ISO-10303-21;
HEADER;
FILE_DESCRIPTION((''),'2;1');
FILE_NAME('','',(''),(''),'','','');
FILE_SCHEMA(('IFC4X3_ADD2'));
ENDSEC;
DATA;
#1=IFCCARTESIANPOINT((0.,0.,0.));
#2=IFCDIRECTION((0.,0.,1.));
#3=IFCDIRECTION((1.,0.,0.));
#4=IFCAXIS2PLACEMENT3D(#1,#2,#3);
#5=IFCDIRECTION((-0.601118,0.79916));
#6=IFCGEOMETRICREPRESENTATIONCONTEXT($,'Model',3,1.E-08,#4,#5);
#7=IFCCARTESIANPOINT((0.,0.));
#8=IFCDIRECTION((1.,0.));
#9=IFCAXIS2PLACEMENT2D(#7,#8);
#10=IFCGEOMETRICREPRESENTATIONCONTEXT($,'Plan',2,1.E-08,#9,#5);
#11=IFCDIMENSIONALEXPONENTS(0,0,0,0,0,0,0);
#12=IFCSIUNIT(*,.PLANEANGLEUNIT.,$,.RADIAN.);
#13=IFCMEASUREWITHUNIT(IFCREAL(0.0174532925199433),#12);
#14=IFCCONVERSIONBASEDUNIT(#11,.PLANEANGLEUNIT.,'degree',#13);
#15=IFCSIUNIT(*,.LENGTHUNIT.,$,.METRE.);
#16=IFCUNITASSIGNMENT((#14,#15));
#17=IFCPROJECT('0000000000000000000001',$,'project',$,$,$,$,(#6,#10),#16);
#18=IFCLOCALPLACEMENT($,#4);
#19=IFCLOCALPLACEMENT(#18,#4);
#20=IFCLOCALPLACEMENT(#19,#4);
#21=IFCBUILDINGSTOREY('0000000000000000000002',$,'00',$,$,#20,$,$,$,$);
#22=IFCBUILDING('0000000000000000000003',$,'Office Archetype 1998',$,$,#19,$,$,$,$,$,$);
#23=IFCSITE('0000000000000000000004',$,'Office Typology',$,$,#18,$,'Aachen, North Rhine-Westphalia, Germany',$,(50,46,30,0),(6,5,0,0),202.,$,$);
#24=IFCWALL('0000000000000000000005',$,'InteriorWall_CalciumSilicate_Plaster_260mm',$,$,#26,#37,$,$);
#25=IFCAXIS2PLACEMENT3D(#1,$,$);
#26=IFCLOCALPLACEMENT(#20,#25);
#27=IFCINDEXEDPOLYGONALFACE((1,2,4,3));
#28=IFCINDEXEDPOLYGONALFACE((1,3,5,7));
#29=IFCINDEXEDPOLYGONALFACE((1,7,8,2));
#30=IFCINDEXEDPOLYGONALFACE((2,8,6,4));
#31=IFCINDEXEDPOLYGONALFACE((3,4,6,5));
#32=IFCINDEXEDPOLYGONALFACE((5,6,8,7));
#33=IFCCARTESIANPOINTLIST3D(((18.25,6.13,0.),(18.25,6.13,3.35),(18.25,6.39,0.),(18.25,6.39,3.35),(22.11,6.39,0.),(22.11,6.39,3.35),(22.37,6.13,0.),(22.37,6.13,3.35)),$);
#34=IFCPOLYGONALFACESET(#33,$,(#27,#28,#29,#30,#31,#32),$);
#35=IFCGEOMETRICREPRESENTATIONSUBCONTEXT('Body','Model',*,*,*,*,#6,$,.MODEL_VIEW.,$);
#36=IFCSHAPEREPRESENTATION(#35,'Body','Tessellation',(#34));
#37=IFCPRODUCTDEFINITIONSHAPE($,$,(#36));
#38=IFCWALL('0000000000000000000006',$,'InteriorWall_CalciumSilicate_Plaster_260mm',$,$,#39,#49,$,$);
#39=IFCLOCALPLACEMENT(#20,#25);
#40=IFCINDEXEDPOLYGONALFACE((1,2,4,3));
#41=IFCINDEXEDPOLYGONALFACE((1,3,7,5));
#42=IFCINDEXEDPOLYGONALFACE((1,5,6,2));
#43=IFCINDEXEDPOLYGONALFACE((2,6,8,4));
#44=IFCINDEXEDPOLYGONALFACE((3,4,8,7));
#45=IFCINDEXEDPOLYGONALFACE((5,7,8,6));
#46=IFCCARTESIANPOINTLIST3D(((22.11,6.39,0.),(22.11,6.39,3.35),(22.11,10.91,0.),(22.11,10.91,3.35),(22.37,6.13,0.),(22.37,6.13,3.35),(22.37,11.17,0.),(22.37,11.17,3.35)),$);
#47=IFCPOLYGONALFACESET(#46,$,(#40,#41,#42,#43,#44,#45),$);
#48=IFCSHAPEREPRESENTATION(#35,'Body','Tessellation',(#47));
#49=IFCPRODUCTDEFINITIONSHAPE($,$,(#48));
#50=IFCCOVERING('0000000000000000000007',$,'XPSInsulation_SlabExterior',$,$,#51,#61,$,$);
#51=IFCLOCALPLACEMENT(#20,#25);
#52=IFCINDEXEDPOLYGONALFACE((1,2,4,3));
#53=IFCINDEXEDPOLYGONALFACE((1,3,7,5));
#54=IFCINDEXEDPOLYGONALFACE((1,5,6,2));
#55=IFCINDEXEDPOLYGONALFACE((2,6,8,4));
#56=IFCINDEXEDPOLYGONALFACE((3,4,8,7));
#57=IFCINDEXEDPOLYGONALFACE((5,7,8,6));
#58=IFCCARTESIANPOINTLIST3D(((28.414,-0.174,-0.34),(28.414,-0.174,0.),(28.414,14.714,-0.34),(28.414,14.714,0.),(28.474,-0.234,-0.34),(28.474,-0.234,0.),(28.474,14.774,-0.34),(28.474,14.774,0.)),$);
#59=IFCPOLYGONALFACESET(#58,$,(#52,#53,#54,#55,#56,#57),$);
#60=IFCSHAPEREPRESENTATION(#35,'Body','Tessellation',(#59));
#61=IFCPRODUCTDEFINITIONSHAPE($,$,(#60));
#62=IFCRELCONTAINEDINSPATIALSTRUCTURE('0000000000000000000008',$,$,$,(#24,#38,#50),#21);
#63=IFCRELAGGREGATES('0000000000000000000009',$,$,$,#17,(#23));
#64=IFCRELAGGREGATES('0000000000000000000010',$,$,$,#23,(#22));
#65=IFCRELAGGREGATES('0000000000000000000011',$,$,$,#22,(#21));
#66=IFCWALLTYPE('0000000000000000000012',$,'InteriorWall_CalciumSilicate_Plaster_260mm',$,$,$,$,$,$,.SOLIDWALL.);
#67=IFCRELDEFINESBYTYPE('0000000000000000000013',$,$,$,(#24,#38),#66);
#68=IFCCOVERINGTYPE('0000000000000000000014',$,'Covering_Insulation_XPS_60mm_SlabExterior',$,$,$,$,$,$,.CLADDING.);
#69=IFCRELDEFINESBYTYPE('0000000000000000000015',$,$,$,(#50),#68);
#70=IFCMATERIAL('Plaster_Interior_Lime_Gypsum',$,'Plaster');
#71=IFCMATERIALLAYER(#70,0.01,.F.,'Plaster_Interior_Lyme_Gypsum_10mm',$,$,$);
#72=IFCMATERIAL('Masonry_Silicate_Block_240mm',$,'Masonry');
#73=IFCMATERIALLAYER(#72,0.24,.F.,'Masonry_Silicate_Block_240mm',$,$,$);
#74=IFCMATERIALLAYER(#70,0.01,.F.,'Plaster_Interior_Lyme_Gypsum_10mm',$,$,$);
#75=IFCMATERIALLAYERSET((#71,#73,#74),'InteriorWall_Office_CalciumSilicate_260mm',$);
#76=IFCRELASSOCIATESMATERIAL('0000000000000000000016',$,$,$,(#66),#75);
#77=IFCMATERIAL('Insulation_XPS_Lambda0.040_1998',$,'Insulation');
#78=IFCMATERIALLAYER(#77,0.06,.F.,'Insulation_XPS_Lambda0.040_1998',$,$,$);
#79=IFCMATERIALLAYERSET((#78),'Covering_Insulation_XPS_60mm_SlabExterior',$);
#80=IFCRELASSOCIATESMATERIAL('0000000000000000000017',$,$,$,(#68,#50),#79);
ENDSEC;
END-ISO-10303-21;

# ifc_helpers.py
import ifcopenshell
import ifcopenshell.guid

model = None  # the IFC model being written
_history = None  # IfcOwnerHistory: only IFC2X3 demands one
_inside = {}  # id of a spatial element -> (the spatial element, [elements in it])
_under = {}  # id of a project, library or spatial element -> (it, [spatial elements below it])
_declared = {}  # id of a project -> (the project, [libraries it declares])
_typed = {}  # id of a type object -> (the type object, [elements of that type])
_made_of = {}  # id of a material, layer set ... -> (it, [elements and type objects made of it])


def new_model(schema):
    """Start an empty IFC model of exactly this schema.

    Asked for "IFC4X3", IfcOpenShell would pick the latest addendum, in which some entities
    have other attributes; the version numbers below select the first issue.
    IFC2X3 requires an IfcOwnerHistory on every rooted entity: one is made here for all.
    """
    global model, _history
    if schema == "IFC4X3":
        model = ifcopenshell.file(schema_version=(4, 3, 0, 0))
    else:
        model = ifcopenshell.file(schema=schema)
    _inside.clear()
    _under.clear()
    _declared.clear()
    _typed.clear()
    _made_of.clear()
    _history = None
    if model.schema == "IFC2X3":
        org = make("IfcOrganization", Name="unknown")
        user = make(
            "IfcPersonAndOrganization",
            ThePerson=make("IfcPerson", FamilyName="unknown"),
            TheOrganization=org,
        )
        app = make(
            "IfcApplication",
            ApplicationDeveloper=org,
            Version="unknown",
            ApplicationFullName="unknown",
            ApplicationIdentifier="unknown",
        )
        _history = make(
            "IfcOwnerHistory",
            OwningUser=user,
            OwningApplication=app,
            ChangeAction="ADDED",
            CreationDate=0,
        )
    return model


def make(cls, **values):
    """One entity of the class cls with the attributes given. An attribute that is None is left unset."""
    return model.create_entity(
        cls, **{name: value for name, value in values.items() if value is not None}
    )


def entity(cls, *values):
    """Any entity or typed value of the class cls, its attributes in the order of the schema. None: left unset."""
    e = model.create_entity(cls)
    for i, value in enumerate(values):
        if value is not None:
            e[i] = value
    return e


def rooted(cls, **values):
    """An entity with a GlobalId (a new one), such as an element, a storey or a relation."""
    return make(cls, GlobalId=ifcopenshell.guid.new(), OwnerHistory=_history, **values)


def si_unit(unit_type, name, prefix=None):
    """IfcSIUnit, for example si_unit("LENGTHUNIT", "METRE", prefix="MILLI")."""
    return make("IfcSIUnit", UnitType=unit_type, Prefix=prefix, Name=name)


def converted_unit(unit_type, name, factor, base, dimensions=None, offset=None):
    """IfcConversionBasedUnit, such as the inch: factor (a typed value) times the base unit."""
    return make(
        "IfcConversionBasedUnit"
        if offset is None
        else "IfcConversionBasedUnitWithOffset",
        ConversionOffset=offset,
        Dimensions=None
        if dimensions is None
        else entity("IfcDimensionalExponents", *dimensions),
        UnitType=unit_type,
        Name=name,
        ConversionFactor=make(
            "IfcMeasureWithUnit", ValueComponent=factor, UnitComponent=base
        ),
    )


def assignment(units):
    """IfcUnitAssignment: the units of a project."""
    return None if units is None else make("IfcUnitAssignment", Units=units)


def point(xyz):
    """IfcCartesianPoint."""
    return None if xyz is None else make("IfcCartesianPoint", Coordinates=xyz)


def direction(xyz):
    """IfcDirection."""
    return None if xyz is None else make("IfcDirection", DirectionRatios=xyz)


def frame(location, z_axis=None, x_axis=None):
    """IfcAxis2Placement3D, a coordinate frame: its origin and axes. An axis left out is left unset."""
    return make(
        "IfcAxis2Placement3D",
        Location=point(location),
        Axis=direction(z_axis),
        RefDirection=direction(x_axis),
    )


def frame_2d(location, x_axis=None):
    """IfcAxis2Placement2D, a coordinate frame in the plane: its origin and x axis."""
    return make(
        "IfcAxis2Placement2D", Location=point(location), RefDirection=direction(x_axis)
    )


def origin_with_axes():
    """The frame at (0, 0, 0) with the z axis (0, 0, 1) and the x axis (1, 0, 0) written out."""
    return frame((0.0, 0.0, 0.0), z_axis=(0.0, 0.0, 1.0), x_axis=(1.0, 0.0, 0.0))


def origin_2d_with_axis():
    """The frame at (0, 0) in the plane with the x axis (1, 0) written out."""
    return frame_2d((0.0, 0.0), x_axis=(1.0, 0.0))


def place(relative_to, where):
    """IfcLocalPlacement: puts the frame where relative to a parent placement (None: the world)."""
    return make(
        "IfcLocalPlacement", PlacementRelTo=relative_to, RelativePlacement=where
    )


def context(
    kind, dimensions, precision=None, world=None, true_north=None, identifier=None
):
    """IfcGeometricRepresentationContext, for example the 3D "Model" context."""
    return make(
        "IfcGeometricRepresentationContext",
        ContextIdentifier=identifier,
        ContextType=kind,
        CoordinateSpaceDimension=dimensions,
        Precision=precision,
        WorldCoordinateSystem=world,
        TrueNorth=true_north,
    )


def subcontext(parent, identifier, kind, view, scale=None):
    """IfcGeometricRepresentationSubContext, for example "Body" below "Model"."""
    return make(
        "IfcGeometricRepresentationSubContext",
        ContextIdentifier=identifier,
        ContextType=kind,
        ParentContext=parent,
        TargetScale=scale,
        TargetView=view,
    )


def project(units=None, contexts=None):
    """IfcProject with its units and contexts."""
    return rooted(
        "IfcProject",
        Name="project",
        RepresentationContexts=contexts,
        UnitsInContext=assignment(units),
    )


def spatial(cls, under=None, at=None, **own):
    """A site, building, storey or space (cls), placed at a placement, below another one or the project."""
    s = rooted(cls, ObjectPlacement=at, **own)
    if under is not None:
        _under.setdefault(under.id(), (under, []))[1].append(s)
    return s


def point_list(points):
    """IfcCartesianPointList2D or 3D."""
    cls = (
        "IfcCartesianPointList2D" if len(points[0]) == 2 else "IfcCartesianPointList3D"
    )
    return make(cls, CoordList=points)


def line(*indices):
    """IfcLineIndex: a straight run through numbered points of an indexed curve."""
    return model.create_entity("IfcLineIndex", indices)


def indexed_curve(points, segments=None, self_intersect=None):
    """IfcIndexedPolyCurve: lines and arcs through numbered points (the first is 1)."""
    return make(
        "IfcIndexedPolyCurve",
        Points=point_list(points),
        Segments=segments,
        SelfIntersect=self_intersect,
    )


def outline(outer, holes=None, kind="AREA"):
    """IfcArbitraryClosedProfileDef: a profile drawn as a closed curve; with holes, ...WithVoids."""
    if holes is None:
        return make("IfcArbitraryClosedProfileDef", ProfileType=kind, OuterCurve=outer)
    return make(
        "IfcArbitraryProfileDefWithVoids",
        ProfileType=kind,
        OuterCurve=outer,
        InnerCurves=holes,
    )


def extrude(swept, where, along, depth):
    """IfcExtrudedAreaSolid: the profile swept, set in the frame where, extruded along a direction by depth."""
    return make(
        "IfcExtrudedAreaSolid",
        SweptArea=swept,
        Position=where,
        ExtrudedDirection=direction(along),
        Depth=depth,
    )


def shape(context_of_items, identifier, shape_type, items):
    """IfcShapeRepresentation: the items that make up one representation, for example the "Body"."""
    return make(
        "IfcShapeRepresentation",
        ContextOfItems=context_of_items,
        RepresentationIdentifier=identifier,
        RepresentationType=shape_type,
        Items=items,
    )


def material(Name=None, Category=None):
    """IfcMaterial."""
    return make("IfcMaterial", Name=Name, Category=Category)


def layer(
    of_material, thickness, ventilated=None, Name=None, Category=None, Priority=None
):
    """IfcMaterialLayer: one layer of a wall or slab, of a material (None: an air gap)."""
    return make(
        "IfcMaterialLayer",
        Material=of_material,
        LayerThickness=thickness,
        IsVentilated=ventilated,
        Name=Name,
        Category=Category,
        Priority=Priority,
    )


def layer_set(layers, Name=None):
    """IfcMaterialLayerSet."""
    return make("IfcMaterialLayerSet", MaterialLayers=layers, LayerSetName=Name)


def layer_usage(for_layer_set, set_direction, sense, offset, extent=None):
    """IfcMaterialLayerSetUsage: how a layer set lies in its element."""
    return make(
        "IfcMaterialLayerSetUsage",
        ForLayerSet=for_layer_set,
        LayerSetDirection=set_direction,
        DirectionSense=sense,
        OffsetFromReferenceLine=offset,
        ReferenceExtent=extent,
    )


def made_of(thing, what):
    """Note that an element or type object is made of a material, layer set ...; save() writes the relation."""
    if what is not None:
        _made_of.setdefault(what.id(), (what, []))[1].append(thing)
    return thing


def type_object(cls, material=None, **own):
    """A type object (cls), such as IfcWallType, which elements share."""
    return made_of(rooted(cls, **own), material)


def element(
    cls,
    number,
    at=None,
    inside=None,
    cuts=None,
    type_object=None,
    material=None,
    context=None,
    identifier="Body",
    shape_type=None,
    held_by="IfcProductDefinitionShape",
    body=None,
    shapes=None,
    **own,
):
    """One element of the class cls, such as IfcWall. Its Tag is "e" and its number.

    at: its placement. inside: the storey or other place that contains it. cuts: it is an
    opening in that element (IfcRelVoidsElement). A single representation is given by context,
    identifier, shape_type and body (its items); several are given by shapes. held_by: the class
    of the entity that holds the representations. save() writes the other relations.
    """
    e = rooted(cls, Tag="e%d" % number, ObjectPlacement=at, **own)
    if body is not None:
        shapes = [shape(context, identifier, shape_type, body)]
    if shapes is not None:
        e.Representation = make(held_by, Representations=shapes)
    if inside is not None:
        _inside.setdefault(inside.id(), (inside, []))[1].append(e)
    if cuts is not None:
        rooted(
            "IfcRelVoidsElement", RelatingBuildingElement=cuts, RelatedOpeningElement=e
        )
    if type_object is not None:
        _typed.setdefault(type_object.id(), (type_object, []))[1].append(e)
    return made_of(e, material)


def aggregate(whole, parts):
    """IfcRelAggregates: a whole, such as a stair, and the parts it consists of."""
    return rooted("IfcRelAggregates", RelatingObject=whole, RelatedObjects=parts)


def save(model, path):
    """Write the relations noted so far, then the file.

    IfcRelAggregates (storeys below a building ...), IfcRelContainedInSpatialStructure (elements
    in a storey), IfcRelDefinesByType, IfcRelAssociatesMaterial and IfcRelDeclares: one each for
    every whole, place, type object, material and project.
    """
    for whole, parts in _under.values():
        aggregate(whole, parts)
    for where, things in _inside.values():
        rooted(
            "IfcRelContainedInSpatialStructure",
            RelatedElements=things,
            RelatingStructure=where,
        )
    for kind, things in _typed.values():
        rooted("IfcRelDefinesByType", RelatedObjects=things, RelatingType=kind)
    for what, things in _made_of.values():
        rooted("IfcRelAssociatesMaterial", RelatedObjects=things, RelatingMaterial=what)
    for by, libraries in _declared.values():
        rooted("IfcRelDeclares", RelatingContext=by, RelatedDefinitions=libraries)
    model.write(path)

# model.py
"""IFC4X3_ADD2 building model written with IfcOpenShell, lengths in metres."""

from ifc_helpers import new_model, entity, si_unit, converted_unit, direction, frame, origin_with_axes, origin_2d_with_axis, place, context, subcontext, project, spatial, line, indexed_curve, outline, extrude, material, layer, layer_set, layer_usage, type_object, element, save


model = new_model("IFC4X3_ADD2")

# Units and contexts
model_context = context("Model", 3, precision=1e-08, world=origin_with_axes(), true_north=direction((-0.601118, 0.79916)))
plan_context = context("Plan", 2, precision=1e-08, world=origin_2d_with_axis(), true_north=direction((-0.601118, 0.79916)))
body_context = subcontext(model_context, "Body", "Model", "MODEL_VIEW")
ifc_project = project(units=[converted_unit("PLANEANGLEUNIT", "degree", entity("IfcReal", 0.0174532925199433), si_unit("PLANEANGLEUNIT", "RADIAN"), dimensions=[0, 0, 0, 0, 0, 0, 0]), si_unit("LENGTHUNIT", "METRE")], contexts=[model_context, plan_context])

# Site, building, storey
site_placement = place(None, origin_with_axes())
site = spatial("IfcSite", under=ifc_project, at=site_placement, Name="Office Typology", LongName="Aachen, North Rhine-Westphalia, Germany", RefLatitude=(50, 46, 30, 0), RefLongitude=(6, 5, 0, 0), RefElevation=202.0)
building_placement = place(site_placement, origin_with_axes())
building = spatial("IfcBuilding", under=site, at=building_placement, Name="Office Archetype 1998")
storey_placement = place(building_placement, origin_with_axes())
storey = spatial("IfcBuildingStorey", under=building, at=storey_placement, Name="00")

# Walls
ifc_material_1 = material(Name="Plaster_Interior_Lime_Gypsum", Category="Plaster")
ifc_layer_1 = layer(ifc_material_1, 0.01, ventilated=False, Name="Plaster_Interior_Lyme_Gypsum_10mm")
ifc_material_2 = material(Name="Masonry_Silicate_Block_240mm", Category="Masonry")
ifc_layer_2 = layer(ifc_material_2, 0.24, ventilated=False, Name="Masonry_Silicate_Block_240mm")
ifc_layer_3 = layer(ifc_material_1, 0.01, ventilated=False, Name="Plaster_Interior_Lyme_Gypsum_10mm")
ifc_layer_set_1 = layer_set([ifc_layer_1, ifc_layer_2, ifc_layer_3], Name="InteriorWall_Office_CalciumSilicate_260mm")
wall_type_1 = type_object("IfcWallType", Name="InteriorWall_CalciumSilicate_Plaster_260mm", PredefinedType="SOLIDWALL", material=ifc_layer_set_1)
wall_1_placement = place(storey_placement, frame((18.25, 6.13, 0.0), z_axis=(0.0, 0.0, 1.0), x_axis=(1.0, 0.0, 0.0)))
element("IfcWall", 1, at=wall_1_placement, inside=storey, type_object=wall_type_1, Name="InteriorWall_CalciumSilicate_Plaster_260mm", context=body_context, shape_type="SweptSolid", body=[
    extrude(outline(indexed_curve([(0.0, 0.0), (0.0, 0.26), (3.86, 0.26), (4.12, 0.0)], segments=[line(1, 2, 3, 4, 1)])), origin_with_axes(), (0.0, 0.0, 1.0), 3.35),
])
wall_2_placement = place(storey_placement, frame((22.37, 6.13, 0.0), z_axis=(0.0, 0.0, 1.0), x_axis=(0.0, 1.0, 0.0)))
element("IfcWall", 2, at=wall_2_placement, inside=storey, type_object=wall_type_1, Name="InteriorWall_CalciumSilicate_Plaster_260mm", context=body_context, shape_type="SweptSolid", body=[
    extrude(outline(indexed_curve([(0.0, 0.0), (0.26, 0.26), (4.78, 0.26), (5.04, 0.0)], segments=[line(1, 2, 3, 4, 1)])), origin_with_axes(), (0.0, 0.0, 1.0), 3.35),
])

# Covering
ifc_material_3 = material(Name="Insulation_XPS_Lambda0.040_1998", Category="Insulation")
ifc_layer_4 = layer(ifc_material_3, 0.06, ventilated=False, Name="Insulation_XPS_Lambda0.040_1998")
ifc_layer_set_2 = layer_set([ifc_layer_4], Name="Covering_Insulation_XPS_60mm_SlabExterior")
ifc_layer_usage_1 = layer_usage(ifc_layer_set_2, "AXIS2", "POSITIVE", 0.0)
covering_type = type_object("IfcCoveringType", Name="Covering_Insulation_XPS_60mm_SlabExterior", PredefinedType="CLADDING", material=ifc_layer_set_2)
covering_placement = place(storey_placement, frame((28.474, -0.234, -0.34), z_axis=(0.0, 0.0, 1.0), x_axis=(0.0, 1.0, 0.0)))
element("IfcCovering", 3, at=covering_placement, inside=storey, type_object=covering_type, material=ifc_layer_usage_1, Name="XPSInsulation_SlabExterior", context=body_context, shape_type="SweptSolid", body=[
    extrude(outline(indexed_curve([(0.0, 0.0), (0.06, 0.06), (14.948, 0.06), (15.008, 0.0)], segments=[line(1, 2, 3, 4, 1)])), origin_with_axes(), (0.0, 0.0, 1.0), 0.34),
])

save(model, "model.ifc")
